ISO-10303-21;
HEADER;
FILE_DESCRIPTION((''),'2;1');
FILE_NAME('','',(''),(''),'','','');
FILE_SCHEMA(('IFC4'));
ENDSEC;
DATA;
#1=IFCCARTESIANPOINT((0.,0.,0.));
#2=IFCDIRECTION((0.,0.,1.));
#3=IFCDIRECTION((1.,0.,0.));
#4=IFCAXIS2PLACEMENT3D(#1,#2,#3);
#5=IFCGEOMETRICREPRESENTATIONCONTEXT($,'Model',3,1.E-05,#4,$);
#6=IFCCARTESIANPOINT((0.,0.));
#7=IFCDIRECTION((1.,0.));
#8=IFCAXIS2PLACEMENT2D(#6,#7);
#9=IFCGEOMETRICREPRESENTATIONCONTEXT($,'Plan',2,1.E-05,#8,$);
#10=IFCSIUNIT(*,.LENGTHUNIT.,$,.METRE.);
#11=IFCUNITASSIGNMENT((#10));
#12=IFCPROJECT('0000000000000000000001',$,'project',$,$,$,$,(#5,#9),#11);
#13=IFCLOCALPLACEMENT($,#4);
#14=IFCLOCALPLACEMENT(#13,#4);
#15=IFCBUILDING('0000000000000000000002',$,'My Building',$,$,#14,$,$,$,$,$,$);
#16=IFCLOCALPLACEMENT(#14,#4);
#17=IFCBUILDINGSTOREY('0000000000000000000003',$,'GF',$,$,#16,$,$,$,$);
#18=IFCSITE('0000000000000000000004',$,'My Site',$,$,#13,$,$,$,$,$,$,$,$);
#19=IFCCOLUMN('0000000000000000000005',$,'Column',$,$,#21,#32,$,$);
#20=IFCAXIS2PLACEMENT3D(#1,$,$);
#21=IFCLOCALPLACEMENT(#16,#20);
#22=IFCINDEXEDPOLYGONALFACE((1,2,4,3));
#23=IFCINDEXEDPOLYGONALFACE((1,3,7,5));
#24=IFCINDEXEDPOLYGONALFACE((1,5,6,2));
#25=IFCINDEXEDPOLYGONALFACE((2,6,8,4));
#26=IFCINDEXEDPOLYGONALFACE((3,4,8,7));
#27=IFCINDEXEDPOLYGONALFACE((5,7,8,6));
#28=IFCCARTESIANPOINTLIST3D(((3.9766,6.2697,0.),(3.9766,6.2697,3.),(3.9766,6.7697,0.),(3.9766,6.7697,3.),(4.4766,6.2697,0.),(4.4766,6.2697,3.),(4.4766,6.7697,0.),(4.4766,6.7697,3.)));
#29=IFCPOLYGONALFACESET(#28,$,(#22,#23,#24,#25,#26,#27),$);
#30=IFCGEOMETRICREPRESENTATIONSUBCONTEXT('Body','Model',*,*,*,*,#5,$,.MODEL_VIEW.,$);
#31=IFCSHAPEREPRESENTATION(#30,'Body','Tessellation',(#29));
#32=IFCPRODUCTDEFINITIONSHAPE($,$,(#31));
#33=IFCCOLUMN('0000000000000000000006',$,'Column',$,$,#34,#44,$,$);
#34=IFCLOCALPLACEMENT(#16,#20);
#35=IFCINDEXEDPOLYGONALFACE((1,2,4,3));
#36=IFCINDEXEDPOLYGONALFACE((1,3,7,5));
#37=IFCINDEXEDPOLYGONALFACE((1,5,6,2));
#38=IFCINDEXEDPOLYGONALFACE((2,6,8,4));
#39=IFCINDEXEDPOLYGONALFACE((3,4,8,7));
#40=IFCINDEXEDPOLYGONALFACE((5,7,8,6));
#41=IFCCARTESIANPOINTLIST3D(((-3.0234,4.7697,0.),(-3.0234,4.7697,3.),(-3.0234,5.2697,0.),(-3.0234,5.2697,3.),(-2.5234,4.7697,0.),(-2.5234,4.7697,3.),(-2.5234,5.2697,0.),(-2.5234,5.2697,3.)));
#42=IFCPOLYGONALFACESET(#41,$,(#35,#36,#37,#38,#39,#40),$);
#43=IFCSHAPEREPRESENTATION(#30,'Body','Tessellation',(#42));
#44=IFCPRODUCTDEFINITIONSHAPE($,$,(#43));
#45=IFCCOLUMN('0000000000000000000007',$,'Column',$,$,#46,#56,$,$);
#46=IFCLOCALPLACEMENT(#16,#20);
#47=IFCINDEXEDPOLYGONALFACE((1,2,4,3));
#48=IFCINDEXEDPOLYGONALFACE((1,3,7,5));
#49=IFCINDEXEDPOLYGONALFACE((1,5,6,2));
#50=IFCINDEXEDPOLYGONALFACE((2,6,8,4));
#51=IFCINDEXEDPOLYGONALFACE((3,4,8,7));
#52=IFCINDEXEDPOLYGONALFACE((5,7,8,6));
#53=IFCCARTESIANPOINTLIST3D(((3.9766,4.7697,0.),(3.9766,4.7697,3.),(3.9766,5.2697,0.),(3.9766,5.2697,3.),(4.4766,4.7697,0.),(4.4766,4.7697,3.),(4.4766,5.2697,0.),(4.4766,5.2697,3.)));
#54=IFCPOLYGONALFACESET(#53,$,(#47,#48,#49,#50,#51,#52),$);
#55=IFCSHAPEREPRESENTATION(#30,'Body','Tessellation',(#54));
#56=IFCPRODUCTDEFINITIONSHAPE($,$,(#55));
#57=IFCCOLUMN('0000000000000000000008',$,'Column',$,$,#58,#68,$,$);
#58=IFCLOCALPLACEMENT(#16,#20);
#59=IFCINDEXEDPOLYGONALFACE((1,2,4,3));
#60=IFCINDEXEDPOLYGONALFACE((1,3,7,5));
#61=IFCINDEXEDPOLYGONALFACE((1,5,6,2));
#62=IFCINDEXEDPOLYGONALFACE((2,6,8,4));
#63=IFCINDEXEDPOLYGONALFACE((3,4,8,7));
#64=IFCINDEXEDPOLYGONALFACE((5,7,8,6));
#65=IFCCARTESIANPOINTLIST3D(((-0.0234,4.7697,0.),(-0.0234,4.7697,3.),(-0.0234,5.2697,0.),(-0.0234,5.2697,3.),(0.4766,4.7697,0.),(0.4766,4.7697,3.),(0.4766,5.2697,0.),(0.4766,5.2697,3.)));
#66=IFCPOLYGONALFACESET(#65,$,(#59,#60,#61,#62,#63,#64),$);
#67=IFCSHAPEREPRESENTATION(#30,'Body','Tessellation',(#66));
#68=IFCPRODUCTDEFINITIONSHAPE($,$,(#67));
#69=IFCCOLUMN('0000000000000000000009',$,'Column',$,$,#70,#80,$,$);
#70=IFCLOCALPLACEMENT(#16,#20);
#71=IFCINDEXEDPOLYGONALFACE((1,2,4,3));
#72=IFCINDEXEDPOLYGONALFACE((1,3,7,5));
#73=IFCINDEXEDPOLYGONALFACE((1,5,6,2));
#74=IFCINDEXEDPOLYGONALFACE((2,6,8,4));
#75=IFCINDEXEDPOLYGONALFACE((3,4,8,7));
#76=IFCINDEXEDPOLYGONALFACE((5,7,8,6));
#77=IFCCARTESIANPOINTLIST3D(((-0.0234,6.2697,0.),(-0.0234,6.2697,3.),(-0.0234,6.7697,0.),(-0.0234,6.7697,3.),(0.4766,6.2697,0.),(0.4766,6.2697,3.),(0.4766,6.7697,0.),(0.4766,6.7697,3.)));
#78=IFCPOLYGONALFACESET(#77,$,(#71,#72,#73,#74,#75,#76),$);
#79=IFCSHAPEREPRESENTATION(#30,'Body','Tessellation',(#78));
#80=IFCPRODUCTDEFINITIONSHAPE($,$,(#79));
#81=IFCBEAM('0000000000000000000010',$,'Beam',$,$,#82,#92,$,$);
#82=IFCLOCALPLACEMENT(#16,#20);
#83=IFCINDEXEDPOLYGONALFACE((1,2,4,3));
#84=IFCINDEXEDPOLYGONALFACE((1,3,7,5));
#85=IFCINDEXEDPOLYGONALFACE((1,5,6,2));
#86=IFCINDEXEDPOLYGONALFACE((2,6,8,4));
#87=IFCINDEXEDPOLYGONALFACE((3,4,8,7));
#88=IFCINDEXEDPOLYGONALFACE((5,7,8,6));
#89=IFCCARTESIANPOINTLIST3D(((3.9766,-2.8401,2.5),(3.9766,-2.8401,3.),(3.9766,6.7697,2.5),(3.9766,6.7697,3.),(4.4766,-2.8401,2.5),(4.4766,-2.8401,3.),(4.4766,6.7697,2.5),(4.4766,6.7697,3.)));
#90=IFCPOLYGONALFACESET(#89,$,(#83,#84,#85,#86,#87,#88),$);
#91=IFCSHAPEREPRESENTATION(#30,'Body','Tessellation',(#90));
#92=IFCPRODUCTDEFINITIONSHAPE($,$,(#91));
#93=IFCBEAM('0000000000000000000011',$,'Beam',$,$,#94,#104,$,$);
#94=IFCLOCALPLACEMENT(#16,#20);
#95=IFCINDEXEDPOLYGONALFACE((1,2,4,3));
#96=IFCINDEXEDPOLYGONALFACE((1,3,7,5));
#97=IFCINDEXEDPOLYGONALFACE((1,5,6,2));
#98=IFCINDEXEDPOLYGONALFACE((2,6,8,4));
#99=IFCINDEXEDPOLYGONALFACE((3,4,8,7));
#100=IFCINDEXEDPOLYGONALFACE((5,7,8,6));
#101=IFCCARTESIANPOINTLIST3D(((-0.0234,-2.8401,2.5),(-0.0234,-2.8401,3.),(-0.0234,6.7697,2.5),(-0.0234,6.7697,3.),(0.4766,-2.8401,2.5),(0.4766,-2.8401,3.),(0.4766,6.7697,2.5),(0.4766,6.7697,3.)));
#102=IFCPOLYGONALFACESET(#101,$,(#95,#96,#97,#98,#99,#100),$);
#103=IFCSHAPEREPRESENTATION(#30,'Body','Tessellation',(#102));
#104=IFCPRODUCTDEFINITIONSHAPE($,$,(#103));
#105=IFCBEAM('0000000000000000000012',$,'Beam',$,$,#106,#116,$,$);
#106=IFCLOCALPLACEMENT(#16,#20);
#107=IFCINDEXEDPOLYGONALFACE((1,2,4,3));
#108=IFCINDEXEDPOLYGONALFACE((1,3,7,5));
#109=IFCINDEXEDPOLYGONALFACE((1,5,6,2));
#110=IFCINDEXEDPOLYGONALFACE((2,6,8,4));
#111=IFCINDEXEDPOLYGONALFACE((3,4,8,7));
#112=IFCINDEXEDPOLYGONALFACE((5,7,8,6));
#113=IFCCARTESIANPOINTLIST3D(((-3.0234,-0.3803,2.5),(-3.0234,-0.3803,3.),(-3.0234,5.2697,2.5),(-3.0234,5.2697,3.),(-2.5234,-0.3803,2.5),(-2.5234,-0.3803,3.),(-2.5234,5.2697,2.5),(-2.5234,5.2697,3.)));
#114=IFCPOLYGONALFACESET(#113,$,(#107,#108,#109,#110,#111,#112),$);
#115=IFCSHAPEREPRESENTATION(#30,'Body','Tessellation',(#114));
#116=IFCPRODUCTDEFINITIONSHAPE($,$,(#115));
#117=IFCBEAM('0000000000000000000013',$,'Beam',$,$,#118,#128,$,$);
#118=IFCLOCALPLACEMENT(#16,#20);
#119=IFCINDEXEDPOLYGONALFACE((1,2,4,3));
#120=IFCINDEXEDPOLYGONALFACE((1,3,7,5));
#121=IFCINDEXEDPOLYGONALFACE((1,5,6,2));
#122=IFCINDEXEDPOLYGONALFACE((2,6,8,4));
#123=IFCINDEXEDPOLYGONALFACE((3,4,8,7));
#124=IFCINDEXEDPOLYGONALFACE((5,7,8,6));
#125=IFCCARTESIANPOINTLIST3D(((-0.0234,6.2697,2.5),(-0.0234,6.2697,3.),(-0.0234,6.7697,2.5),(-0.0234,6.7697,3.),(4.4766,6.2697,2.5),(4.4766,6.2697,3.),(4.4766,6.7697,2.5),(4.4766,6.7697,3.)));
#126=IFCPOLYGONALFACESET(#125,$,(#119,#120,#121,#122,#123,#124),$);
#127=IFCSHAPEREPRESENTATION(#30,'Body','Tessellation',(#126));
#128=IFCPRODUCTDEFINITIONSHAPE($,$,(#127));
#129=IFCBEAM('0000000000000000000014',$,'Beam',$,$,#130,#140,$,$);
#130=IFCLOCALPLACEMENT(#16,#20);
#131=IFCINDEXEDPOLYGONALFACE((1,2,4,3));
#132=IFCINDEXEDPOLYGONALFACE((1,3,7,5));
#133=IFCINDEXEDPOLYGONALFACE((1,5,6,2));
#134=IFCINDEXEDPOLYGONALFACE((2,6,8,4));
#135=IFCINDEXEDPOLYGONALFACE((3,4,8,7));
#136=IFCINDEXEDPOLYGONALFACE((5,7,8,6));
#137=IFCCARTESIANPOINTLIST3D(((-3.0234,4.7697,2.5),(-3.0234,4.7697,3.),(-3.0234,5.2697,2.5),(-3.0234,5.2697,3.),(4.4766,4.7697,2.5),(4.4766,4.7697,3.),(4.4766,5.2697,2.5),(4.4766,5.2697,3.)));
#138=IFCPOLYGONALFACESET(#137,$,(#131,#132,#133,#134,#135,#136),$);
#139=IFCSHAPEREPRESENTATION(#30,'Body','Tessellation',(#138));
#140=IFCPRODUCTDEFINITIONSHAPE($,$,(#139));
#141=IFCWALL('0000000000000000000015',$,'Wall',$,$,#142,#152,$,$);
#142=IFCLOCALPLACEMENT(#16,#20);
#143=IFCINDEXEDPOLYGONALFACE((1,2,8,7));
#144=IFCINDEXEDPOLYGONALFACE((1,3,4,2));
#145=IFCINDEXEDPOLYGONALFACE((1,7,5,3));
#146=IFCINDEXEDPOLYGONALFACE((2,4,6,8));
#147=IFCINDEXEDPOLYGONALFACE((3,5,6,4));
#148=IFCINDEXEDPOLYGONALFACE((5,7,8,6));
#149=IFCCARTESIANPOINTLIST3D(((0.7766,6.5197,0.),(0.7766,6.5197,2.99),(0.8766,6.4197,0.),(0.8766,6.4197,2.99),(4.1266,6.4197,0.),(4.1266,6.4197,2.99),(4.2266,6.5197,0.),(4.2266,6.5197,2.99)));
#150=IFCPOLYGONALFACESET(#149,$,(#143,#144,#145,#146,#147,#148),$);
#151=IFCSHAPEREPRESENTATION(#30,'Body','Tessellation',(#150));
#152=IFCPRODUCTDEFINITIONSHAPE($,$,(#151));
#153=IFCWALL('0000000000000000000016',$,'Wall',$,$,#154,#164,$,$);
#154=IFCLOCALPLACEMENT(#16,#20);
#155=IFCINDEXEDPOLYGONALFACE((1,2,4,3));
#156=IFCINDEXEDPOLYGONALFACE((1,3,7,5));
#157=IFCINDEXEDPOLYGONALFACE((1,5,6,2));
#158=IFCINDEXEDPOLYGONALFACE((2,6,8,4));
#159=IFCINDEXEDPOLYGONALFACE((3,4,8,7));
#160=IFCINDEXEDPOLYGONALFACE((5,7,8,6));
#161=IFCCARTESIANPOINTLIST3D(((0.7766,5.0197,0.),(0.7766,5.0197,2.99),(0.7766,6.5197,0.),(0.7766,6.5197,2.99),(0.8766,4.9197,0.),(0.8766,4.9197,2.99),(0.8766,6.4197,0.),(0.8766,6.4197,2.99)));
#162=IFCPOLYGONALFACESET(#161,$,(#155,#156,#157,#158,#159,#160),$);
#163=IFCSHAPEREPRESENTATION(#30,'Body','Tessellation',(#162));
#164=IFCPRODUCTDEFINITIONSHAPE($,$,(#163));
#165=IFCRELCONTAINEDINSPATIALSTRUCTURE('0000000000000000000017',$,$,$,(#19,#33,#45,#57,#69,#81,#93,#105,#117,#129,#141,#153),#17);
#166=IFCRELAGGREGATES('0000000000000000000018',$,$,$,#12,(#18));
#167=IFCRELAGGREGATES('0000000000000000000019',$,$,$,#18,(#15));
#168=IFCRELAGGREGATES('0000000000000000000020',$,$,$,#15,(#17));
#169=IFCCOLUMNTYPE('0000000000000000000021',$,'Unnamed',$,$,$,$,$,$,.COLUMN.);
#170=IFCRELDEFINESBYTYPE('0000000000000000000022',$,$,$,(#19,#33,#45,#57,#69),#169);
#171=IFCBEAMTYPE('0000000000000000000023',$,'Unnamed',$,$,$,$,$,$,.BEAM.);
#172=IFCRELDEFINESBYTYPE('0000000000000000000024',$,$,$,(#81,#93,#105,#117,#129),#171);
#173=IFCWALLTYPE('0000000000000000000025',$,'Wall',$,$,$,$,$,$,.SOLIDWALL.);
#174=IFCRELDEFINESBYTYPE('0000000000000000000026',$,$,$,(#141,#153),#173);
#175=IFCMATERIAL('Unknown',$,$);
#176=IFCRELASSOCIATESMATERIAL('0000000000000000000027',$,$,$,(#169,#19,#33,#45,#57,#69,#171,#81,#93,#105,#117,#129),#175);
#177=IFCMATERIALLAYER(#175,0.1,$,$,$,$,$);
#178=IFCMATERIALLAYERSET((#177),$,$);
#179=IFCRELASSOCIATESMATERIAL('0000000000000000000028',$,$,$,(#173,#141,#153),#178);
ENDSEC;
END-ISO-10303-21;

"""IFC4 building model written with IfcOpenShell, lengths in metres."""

from ifc_helpers import new_model, si_unit, frame, origin_with_axes, origin_2d_with_axis, place, context, subcontext, project, spatial, line, indexed_curve, rectangle, outline, extrude, material, layer, layer_set, layer_usage, material_profile, profile_set, profile_usage, type_object, element, save


model = new_model("IFC4")

# Units and contexts
model_context = context("Model", 3, precision=1e-05, world=origin_with_axes())
plan_context = context("Plan", 2, precision=1e-05, world=origin_2d_with_axis())
body_context_1 = subcontext(model_context, "Body", "Model", "MODEL_VIEW")
ifc_project = project(units=[si_unit("LENGTHUNIT", "METRE")], contexts=[model_context, plan_context])

# Site, building, storey
site_placement = place(None, origin_with_axes())
site = spatial("IfcSite", under=ifc_project, at=site_placement, Name="My Site")
building_placement = place(site_placement, origin_with_axes())
building = spatial("IfcBuilding", under=site, at=building_placement, Name="My Building")
storey_placement = place(building_placement, origin_with_axes())
storey = spatial("IfcBuildingStorey", under=building, at=storey_placement, Name="GF")

# Columns
ifc_material_1 = material(Name="Unknown")
ifc_material_profile_1 = material_profile(ifc_material_1, rectangle(XDim=0.5, YDim=0.5))
ifc_profile_set_1 = profile_set([ifc_material_profile_1])
ifc_profile_usage_1 = profile_usage(ifc_profile_set_1, cardinal=5)
column_type = type_object("IfcColumnType", Name="Unnamed", PredefinedType="COLUMN", material=ifc_profile_set_1)
column_1_placement = place(storey_placement, frame((4.2266, 6.5197, 0.0), z_axis=(0.0, 0.0, 1.0), x_axis=(1.0, 0.0, 0.0)))
element("IfcColumn", 1, at=column_1_placement, inside=storey, type_object=column_type, material=ifc_profile_usage_1, Name="Column", context=body_context_1, shape_type="SweptSolid", body=[
    extrude(rectangle(XDim=0.5, YDim=0.5), origin_with_axes(), (0.0, 0.0, 1.0), 3.0),
])
ifc_profile_usage_2 = profile_usage(ifc_profile_set_1, cardinal=5)
column_2_placement = place(storey_placement, frame((-2.7734, 5.0197, 0.0), z_axis=(0.0, 0.0, 1.0), x_axis=(1.0, 0.0, 0.0)))
element("IfcColumn", 2, at=column_2_placement, inside=storey, type_object=column_type, material=ifc_profile_usage_2, Name="Column", context=body_context_1, shape_type="SweptSolid", body=[
    extrude(rectangle(XDim=0.5, YDim=0.5), origin_with_axes(), (0.0, 0.0, 1.0), 3.0),
])
ifc_profile_usage_3 = profile_usage(ifc_profile_set_1, cardinal=5)
column_3_placement = place(storey_placement, frame((4.2266, 5.0197, 0.0), z_axis=(0.0, 0.0, 1.0), x_axis=(1.0, 0.0, 0.0)))
element("IfcColumn", 3, at=column_3_placement, inside=storey, type_object=column_type, material=ifc_profile_usage_3, Name="Column", context=body_context_1, shape_type="SweptSolid", body=[
    extrude(rectangle(XDim=0.5, YDim=0.5), origin_with_axes(), (0.0, 0.0, 1.0), 3.0),
])
ifc_profile_usage_4 = profile_usage(ifc_profile_set_1, cardinal=5)
column_4_placement = place(storey_placement, frame((0.2266, 5.0197, 0.0), z_axis=(0.0, 0.0, 1.0), x_axis=(1.0, 0.0, 0.0)))
element("IfcColumn", 4, at=column_4_placement, inside=storey, type_object=column_type, material=ifc_profile_usage_4, Name="Column", context=body_context_1, shape_type="SweptSolid", body=[
    extrude(rectangle(XDim=0.5, YDim=0.5), origin_with_axes(), (0.0, 0.0, 1.0), 3.0),
])
ifc_profile_usage_5 = profile_usage(ifc_profile_set_1, cardinal=5)
column_5_placement = place(storey_placement, frame((0.2266, 6.5197, 0.0), z_axis=(0.0, 0.0, 1.0), x_axis=(1.0, 0.0, 0.0)))
element("IfcColumn", 5, at=column_5_placement, inside=storey, type_object=column_type, material=ifc_profile_usage_5, Name="Column", context=body_context_1, shape_type="SweptSolid", body=[
    extrude(rectangle(XDim=0.5, YDim=0.5), origin_with_axes(), (0.0, 0.0, 1.0), 3.0),
])

# Beams
ifc_material_profile_2 = material_profile(ifc_material_1, rectangle(XDim=0.5, YDim=0.5))
ifc_profile_set_2 = profile_set([ifc_material_profile_2])
ifc_profile_usage_6 = profile_usage(ifc_profile_set_2, cardinal=7)
beam_type = type_object("IfcBeamType", Name="Unnamed", PredefinedType="BEAM", material=ifc_profile_set_2)
beam_1_placement = place(storey_placement, frame((4.4766, 6.7697, 3.0), z_axis=(0.0, -1.0, 0.0), x_axis=(1.0, 0.0, 0.0)))
element("IfcBeam", 6, at=beam_1_placement, inside=storey, type_object=beam_type, material=ifc_profile_usage_6, Name="Beam", context=body_context_1, shape_type="SweptSolid", body=[
    extrude(rectangle(XDim=0.5, YDim=0.5), frame((-0.25, -0.25, 0.0), z_axis=(0.0, 0.0, 1.0), x_axis=(1.0, 0.0, 0.0)), (0.0, 0.0, 1.0), 9.6098),
])
ifc_profile_usage_7 = profile_usage(ifc_profile_set_2, cardinal=7)
beam_2_placement = place(storey_placement, frame((0.4766, 6.7697, 3.0), z_axis=(0.0, -1.0, 0.0), x_axis=(1.0, 0.0, 0.0)))
element("IfcBeam", 7, at=beam_2_placement, inside=storey, type_object=beam_type, material=ifc_profile_usage_7, Name="Beam", context=body_context_1, shape_type="SweptSolid", body=[
    extrude(rectangle(XDim=0.5, YDim=0.5), frame((-0.25, -0.25, 0.0), z_axis=(0.0, 0.0, 1.0), x_axis=(1.0, 0.0, 0.0)), (0.0, 0.0, 1.0), 9.6098),
])
ifc_profile_usage_8 = profile_usage(ifc_profile_set_2, cardinal=7)
beam_3_placement = place(storey_placement, frame((-2.5234, 5.2697, 3.0), z_axis=(0.0, -1.0, 0.0), x_axis=(1.0, 0.0, 0.0)))
element("IfcBeam", 8, at=beam_3_placement, inside=storey, type_object=beam_type, material=ifc_profile_usage_8, Name="Beam", context=body_context_1, shape_type="SweptSolid", body=[
    extrude(rectangle(XDim=0.5, YDim=0.5), frame((-0.25, -0.25, 0.0), z_axis=(0.0, 0.0, 1.0), x_axis=(1.0, 0.0, 0.0)), (0.0, 0.0, 1.0), 5.65),
])
ifc_profile_usage_9 = profile_usage(ifc_profile_set_2, cardinal=7)
beam_4_placement = place(storey_placement, frame((4.4766, 6.2697, 3.0), z_axis=(-1.0, 0.0, 0.0), x_axis=(0.0, -1.0, 0.0)))
element("IfcBeam", 9, at=beam_4_placement, inside=storey, type_object=beam_type, material=ifc_profile_usage_9, Name="Beam", context=body_context_1, shape_type="SweptSolid", body=[
    extrude(rectangle(XDim=0.5, YDim=0.5), frame((-0.25, -0.25, 0.0), z_axis=(0.0, 0.0, 1.0), x_axis=(1.0, 0.0, 0.0)), (0.0, 0.0, 1.0), 4.5),
])
ifc_profile_usage_10 = profile_usage(ifc_profile_set_2, cardinal=7)
beam_5_placement = place(storey_placement, frame((4.4766, 4.7697, 3.0), z_axis=(-1.0, 0.0, 0.0), x_axis=(0.0, -1.0, 0.0)))
element("IfcBeam", 10, at=beam_5_placement, inside=storey, type_object=beam_type, material=ifc_profile_usage_10, Name="Beam", context=body_context_1, shape_type="SweptSolid", body=[
    extrude(rectangle(XDim=0.5, YDim=0.5), frame((-0.25, -0.25, 0.0), z_axis=(0.0, 0.0, 1.0), x_axis=(1.0, 0.0, 0.0)), (0.0, 0.0, 1.0), 7.5),
])

# Walls
ifc_layer_1 = layer(ifc_material_1, 0.1)
ifc_layer_set_1 = layer_set([ifc_layer_1])
ifc_layer_usage_1 = layer_usage(ifc_layer_set_1, "AXIS2", "POSITIVE", 0.0)
wall_type = type_object("IfcWallType", Name="Wall", PredefinedType="SOLIDWALL", material=ifc_layer_set_1)
wall_1_placement = place(storey_placement, frame((4.2266, 6.5197, 0.0), z_axis=(0.0, 0.0, 1.0), x_axis=(-1.0, 0.0, 0.0)))
element("IfcWall", 11, at=wall_1_placement, inside=storey, type_object=wall_type, material=ifc_layer_usage_1, Name="Wall", context=body_context_1, shape_type="SweptSolid", body=[
    extrude(outline(indexed_curve([(0.0, 0.0), (0.1, 0.1), (3.35, 0.1), (3.45, 0.0)], segments=[line(1, 2, 3, 4, 1)])), origin_with_axes(), (0.0, 0.0, 1.0), 2.99),
])
ifc_layer_usage_2 = layer_usage(ifc_layer_set_1, "AXIS2", "POSITIVE", 0.0)
wall_2_placement = place(storey_placement, frame((0.7766, 6.5197, 0.0), z_axis=(0.0, 0.0, 1.0), x_axis=(0.0, -1.0, 0.0)))
element("IfcWall", 12, at=wall_2_placement, inside=storey, type_object=wall_type, material=ifc_layer_usage_2, Name="Wall", context=body_context_1, shape_type="SweptSolid", body=[
    extrude(outline(indexed_curve([(0.0, 0.0), (0.1, 0.1), (1.6, 0.1), (1.5, 0.0)], segments=[line(1, 2, 3, 4, 1)])), origin_with_axes(), (0.0, 0.0, 1.0), 2.99),
])

save(model, "model.ifc")
